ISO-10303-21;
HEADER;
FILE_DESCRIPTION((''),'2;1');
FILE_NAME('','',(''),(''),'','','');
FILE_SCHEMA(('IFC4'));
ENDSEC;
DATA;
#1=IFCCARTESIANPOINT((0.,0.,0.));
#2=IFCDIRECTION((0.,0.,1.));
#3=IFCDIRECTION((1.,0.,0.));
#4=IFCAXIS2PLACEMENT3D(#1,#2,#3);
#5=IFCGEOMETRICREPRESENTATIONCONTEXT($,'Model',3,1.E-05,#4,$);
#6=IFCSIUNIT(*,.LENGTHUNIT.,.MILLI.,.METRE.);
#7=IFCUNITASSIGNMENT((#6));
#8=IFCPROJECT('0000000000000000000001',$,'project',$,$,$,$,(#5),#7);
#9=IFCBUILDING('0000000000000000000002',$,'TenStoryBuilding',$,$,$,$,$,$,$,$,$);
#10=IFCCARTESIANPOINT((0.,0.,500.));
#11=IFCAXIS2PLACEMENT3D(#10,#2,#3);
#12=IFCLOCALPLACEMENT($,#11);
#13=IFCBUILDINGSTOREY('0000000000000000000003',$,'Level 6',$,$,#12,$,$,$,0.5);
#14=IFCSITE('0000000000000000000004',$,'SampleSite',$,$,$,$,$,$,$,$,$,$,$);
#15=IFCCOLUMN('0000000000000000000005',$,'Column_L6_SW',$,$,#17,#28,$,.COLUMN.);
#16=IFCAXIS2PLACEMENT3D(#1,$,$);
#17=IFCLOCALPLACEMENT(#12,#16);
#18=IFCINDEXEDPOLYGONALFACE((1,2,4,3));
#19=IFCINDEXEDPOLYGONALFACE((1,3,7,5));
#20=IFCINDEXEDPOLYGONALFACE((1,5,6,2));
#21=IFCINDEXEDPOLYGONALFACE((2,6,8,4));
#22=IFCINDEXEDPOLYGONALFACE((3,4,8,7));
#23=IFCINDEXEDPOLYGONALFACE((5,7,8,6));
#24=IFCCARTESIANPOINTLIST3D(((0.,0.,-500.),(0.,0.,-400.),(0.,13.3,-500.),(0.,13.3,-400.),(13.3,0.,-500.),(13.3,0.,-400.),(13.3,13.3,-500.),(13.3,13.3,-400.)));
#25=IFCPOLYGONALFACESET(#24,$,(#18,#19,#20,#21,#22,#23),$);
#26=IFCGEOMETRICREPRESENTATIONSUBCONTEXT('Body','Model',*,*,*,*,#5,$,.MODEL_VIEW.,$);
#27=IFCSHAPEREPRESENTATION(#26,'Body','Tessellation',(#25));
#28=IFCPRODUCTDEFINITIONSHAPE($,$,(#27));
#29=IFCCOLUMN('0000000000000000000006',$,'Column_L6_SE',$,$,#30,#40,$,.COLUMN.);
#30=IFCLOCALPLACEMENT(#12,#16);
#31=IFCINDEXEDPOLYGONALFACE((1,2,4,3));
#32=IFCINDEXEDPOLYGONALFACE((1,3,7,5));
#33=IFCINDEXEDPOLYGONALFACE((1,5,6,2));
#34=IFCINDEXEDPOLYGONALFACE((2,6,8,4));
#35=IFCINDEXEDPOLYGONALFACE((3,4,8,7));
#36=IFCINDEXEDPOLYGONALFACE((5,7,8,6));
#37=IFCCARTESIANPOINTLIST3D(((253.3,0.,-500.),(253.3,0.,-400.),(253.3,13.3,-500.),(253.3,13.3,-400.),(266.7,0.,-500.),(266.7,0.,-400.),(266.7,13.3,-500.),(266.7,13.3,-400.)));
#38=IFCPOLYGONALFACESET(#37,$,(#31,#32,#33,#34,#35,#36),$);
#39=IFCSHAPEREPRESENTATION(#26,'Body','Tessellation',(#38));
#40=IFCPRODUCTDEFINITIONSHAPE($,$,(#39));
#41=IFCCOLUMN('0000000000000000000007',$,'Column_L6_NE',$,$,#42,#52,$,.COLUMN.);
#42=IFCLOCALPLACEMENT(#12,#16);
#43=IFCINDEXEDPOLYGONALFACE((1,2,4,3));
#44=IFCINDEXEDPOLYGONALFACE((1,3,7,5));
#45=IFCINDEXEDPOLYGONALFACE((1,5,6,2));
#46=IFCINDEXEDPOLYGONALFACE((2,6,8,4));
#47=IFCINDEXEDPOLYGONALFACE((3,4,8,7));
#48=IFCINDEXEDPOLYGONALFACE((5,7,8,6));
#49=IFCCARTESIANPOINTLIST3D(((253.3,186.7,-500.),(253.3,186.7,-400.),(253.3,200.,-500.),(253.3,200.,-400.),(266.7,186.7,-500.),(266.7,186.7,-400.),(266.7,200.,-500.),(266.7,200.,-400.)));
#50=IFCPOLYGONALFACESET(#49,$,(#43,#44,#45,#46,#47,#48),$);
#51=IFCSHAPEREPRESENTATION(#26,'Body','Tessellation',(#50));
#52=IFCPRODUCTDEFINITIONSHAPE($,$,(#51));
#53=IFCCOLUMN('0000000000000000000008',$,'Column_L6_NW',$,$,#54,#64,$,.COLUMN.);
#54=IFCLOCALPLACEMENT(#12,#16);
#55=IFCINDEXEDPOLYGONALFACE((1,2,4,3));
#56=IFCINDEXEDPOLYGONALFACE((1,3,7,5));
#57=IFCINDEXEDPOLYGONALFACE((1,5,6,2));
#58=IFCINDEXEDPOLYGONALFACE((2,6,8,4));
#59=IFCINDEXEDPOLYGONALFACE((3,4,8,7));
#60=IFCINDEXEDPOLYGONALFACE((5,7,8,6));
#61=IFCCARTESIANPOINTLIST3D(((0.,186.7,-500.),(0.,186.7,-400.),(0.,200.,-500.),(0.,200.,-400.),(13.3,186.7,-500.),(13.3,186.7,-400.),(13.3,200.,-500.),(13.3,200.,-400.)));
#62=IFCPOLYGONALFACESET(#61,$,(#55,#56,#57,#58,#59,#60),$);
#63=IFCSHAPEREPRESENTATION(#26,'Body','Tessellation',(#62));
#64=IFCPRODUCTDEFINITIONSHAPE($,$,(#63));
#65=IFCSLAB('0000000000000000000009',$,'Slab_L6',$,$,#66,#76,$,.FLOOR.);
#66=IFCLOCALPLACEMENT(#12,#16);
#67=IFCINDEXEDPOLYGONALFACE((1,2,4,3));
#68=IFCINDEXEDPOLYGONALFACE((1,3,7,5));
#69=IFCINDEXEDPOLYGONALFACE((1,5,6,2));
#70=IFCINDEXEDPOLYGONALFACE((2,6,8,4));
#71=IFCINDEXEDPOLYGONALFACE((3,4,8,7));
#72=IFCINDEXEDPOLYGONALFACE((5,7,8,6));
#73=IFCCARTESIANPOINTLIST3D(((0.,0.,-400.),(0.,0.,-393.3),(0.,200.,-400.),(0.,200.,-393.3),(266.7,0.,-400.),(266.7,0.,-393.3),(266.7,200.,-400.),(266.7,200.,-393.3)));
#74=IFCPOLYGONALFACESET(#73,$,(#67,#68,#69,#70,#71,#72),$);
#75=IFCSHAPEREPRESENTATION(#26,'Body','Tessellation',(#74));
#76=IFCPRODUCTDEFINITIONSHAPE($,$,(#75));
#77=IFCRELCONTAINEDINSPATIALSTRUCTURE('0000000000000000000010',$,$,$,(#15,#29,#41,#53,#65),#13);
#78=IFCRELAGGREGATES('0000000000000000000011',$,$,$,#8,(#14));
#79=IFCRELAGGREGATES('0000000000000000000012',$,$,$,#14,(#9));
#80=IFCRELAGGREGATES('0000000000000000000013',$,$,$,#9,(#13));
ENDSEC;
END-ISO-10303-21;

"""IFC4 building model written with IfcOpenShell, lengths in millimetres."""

from ifc_helpers import new_model, si_unit, frame, origin_with_axes, origin_2d, place, context, subcontext, project, spatial, indexed_curve, rectangle, outline, extrude, element, save


model = new_model("IFC4")

# Units and contexts
model_context = context("Model", 3, precision=1e-05, world=origin_with_axes())
body_context = subcontext(model_context, "Body", "Model", "MODEL_VIEW")
ifc_project = project(units=[si_unit("LENGTHUNIT", "METRE", prefix="MILLI")], contexts=[model_context])

# Site, building, storey
site = spatial("IfcSite", under=ifc_project, Name="SampleSite")
building = spatial("IfcBuilding", under=site, Name="TenStoryBuilding")
storey_placement = place(None, frame((0.0, 0.0, 500.0), z_axis=(0.0, 0.0, 1.0), x_axis=(1.0, 0.0, 0.0)))
storey = spatial("IfcBuildingStorey", under=building, at=storey_placement, Name="Level 6", Elevation=0.5)

# Columns
for number, where, z_axis, x_axis, name in (
    (1, (6.7, 6.7, -500.0), (0.0, 0.0, 1.0), (1.0, 0.0, 0.0), "Column_L6_SW"),
    (2, (260.0, 6.7, -500.0), (0.0, 0.0, 1.0), (1.0, 0.0, 0.0), "Column_L6_SE"),
    (3, (260.0, 193.3, -500.0), (0.0, 0.0, 1.0), (1.0, 0.0, 0.0), "Column_L6_NE"),
    (4, (6.7, 193.3, -500.0), (0.0, 0.0, 1.0), (1.0, 0.0, 0.0), "Column_L6_NW"),
):
    element("IfcColumn", number, at=place(storey_placement, frame(where, z_axis=z_axis, x_axis=x_axis)), inside=storey, Name=name, PredefinedType="COLUMN", context=body_context, shape_type="SweptSolid", body=[
        extrude(rectangle(XDim=13.3, YDim=13.3, at=origin_2d()), origin_with_axes(), (0.0, 0.0, 1.0), 100.0),
    ])

# Slab
slab_placement = place(storey_placement, frame((0.0, 0.0, -400.0), z_axis=(0.0, 0.0, 1.0), x_axis=(1.0, 0.0, 0.0)))
element("IfcSlab", 5, at=slab_placement, inside=storey, Name="Slab_L6", PredefinedType="FLOOR", context=body_context, shape_type="SweptSolid", body=[
    extrude(outline(indexed_curve([(0.0, 0.0), (266.7, 0.0), (266.7, 200.0), (0.0, 200.0), (0.0, 0.0)])), None, (0.0, 0.0, 1.0), 6.7),
])

save(model, "model.ifc")
